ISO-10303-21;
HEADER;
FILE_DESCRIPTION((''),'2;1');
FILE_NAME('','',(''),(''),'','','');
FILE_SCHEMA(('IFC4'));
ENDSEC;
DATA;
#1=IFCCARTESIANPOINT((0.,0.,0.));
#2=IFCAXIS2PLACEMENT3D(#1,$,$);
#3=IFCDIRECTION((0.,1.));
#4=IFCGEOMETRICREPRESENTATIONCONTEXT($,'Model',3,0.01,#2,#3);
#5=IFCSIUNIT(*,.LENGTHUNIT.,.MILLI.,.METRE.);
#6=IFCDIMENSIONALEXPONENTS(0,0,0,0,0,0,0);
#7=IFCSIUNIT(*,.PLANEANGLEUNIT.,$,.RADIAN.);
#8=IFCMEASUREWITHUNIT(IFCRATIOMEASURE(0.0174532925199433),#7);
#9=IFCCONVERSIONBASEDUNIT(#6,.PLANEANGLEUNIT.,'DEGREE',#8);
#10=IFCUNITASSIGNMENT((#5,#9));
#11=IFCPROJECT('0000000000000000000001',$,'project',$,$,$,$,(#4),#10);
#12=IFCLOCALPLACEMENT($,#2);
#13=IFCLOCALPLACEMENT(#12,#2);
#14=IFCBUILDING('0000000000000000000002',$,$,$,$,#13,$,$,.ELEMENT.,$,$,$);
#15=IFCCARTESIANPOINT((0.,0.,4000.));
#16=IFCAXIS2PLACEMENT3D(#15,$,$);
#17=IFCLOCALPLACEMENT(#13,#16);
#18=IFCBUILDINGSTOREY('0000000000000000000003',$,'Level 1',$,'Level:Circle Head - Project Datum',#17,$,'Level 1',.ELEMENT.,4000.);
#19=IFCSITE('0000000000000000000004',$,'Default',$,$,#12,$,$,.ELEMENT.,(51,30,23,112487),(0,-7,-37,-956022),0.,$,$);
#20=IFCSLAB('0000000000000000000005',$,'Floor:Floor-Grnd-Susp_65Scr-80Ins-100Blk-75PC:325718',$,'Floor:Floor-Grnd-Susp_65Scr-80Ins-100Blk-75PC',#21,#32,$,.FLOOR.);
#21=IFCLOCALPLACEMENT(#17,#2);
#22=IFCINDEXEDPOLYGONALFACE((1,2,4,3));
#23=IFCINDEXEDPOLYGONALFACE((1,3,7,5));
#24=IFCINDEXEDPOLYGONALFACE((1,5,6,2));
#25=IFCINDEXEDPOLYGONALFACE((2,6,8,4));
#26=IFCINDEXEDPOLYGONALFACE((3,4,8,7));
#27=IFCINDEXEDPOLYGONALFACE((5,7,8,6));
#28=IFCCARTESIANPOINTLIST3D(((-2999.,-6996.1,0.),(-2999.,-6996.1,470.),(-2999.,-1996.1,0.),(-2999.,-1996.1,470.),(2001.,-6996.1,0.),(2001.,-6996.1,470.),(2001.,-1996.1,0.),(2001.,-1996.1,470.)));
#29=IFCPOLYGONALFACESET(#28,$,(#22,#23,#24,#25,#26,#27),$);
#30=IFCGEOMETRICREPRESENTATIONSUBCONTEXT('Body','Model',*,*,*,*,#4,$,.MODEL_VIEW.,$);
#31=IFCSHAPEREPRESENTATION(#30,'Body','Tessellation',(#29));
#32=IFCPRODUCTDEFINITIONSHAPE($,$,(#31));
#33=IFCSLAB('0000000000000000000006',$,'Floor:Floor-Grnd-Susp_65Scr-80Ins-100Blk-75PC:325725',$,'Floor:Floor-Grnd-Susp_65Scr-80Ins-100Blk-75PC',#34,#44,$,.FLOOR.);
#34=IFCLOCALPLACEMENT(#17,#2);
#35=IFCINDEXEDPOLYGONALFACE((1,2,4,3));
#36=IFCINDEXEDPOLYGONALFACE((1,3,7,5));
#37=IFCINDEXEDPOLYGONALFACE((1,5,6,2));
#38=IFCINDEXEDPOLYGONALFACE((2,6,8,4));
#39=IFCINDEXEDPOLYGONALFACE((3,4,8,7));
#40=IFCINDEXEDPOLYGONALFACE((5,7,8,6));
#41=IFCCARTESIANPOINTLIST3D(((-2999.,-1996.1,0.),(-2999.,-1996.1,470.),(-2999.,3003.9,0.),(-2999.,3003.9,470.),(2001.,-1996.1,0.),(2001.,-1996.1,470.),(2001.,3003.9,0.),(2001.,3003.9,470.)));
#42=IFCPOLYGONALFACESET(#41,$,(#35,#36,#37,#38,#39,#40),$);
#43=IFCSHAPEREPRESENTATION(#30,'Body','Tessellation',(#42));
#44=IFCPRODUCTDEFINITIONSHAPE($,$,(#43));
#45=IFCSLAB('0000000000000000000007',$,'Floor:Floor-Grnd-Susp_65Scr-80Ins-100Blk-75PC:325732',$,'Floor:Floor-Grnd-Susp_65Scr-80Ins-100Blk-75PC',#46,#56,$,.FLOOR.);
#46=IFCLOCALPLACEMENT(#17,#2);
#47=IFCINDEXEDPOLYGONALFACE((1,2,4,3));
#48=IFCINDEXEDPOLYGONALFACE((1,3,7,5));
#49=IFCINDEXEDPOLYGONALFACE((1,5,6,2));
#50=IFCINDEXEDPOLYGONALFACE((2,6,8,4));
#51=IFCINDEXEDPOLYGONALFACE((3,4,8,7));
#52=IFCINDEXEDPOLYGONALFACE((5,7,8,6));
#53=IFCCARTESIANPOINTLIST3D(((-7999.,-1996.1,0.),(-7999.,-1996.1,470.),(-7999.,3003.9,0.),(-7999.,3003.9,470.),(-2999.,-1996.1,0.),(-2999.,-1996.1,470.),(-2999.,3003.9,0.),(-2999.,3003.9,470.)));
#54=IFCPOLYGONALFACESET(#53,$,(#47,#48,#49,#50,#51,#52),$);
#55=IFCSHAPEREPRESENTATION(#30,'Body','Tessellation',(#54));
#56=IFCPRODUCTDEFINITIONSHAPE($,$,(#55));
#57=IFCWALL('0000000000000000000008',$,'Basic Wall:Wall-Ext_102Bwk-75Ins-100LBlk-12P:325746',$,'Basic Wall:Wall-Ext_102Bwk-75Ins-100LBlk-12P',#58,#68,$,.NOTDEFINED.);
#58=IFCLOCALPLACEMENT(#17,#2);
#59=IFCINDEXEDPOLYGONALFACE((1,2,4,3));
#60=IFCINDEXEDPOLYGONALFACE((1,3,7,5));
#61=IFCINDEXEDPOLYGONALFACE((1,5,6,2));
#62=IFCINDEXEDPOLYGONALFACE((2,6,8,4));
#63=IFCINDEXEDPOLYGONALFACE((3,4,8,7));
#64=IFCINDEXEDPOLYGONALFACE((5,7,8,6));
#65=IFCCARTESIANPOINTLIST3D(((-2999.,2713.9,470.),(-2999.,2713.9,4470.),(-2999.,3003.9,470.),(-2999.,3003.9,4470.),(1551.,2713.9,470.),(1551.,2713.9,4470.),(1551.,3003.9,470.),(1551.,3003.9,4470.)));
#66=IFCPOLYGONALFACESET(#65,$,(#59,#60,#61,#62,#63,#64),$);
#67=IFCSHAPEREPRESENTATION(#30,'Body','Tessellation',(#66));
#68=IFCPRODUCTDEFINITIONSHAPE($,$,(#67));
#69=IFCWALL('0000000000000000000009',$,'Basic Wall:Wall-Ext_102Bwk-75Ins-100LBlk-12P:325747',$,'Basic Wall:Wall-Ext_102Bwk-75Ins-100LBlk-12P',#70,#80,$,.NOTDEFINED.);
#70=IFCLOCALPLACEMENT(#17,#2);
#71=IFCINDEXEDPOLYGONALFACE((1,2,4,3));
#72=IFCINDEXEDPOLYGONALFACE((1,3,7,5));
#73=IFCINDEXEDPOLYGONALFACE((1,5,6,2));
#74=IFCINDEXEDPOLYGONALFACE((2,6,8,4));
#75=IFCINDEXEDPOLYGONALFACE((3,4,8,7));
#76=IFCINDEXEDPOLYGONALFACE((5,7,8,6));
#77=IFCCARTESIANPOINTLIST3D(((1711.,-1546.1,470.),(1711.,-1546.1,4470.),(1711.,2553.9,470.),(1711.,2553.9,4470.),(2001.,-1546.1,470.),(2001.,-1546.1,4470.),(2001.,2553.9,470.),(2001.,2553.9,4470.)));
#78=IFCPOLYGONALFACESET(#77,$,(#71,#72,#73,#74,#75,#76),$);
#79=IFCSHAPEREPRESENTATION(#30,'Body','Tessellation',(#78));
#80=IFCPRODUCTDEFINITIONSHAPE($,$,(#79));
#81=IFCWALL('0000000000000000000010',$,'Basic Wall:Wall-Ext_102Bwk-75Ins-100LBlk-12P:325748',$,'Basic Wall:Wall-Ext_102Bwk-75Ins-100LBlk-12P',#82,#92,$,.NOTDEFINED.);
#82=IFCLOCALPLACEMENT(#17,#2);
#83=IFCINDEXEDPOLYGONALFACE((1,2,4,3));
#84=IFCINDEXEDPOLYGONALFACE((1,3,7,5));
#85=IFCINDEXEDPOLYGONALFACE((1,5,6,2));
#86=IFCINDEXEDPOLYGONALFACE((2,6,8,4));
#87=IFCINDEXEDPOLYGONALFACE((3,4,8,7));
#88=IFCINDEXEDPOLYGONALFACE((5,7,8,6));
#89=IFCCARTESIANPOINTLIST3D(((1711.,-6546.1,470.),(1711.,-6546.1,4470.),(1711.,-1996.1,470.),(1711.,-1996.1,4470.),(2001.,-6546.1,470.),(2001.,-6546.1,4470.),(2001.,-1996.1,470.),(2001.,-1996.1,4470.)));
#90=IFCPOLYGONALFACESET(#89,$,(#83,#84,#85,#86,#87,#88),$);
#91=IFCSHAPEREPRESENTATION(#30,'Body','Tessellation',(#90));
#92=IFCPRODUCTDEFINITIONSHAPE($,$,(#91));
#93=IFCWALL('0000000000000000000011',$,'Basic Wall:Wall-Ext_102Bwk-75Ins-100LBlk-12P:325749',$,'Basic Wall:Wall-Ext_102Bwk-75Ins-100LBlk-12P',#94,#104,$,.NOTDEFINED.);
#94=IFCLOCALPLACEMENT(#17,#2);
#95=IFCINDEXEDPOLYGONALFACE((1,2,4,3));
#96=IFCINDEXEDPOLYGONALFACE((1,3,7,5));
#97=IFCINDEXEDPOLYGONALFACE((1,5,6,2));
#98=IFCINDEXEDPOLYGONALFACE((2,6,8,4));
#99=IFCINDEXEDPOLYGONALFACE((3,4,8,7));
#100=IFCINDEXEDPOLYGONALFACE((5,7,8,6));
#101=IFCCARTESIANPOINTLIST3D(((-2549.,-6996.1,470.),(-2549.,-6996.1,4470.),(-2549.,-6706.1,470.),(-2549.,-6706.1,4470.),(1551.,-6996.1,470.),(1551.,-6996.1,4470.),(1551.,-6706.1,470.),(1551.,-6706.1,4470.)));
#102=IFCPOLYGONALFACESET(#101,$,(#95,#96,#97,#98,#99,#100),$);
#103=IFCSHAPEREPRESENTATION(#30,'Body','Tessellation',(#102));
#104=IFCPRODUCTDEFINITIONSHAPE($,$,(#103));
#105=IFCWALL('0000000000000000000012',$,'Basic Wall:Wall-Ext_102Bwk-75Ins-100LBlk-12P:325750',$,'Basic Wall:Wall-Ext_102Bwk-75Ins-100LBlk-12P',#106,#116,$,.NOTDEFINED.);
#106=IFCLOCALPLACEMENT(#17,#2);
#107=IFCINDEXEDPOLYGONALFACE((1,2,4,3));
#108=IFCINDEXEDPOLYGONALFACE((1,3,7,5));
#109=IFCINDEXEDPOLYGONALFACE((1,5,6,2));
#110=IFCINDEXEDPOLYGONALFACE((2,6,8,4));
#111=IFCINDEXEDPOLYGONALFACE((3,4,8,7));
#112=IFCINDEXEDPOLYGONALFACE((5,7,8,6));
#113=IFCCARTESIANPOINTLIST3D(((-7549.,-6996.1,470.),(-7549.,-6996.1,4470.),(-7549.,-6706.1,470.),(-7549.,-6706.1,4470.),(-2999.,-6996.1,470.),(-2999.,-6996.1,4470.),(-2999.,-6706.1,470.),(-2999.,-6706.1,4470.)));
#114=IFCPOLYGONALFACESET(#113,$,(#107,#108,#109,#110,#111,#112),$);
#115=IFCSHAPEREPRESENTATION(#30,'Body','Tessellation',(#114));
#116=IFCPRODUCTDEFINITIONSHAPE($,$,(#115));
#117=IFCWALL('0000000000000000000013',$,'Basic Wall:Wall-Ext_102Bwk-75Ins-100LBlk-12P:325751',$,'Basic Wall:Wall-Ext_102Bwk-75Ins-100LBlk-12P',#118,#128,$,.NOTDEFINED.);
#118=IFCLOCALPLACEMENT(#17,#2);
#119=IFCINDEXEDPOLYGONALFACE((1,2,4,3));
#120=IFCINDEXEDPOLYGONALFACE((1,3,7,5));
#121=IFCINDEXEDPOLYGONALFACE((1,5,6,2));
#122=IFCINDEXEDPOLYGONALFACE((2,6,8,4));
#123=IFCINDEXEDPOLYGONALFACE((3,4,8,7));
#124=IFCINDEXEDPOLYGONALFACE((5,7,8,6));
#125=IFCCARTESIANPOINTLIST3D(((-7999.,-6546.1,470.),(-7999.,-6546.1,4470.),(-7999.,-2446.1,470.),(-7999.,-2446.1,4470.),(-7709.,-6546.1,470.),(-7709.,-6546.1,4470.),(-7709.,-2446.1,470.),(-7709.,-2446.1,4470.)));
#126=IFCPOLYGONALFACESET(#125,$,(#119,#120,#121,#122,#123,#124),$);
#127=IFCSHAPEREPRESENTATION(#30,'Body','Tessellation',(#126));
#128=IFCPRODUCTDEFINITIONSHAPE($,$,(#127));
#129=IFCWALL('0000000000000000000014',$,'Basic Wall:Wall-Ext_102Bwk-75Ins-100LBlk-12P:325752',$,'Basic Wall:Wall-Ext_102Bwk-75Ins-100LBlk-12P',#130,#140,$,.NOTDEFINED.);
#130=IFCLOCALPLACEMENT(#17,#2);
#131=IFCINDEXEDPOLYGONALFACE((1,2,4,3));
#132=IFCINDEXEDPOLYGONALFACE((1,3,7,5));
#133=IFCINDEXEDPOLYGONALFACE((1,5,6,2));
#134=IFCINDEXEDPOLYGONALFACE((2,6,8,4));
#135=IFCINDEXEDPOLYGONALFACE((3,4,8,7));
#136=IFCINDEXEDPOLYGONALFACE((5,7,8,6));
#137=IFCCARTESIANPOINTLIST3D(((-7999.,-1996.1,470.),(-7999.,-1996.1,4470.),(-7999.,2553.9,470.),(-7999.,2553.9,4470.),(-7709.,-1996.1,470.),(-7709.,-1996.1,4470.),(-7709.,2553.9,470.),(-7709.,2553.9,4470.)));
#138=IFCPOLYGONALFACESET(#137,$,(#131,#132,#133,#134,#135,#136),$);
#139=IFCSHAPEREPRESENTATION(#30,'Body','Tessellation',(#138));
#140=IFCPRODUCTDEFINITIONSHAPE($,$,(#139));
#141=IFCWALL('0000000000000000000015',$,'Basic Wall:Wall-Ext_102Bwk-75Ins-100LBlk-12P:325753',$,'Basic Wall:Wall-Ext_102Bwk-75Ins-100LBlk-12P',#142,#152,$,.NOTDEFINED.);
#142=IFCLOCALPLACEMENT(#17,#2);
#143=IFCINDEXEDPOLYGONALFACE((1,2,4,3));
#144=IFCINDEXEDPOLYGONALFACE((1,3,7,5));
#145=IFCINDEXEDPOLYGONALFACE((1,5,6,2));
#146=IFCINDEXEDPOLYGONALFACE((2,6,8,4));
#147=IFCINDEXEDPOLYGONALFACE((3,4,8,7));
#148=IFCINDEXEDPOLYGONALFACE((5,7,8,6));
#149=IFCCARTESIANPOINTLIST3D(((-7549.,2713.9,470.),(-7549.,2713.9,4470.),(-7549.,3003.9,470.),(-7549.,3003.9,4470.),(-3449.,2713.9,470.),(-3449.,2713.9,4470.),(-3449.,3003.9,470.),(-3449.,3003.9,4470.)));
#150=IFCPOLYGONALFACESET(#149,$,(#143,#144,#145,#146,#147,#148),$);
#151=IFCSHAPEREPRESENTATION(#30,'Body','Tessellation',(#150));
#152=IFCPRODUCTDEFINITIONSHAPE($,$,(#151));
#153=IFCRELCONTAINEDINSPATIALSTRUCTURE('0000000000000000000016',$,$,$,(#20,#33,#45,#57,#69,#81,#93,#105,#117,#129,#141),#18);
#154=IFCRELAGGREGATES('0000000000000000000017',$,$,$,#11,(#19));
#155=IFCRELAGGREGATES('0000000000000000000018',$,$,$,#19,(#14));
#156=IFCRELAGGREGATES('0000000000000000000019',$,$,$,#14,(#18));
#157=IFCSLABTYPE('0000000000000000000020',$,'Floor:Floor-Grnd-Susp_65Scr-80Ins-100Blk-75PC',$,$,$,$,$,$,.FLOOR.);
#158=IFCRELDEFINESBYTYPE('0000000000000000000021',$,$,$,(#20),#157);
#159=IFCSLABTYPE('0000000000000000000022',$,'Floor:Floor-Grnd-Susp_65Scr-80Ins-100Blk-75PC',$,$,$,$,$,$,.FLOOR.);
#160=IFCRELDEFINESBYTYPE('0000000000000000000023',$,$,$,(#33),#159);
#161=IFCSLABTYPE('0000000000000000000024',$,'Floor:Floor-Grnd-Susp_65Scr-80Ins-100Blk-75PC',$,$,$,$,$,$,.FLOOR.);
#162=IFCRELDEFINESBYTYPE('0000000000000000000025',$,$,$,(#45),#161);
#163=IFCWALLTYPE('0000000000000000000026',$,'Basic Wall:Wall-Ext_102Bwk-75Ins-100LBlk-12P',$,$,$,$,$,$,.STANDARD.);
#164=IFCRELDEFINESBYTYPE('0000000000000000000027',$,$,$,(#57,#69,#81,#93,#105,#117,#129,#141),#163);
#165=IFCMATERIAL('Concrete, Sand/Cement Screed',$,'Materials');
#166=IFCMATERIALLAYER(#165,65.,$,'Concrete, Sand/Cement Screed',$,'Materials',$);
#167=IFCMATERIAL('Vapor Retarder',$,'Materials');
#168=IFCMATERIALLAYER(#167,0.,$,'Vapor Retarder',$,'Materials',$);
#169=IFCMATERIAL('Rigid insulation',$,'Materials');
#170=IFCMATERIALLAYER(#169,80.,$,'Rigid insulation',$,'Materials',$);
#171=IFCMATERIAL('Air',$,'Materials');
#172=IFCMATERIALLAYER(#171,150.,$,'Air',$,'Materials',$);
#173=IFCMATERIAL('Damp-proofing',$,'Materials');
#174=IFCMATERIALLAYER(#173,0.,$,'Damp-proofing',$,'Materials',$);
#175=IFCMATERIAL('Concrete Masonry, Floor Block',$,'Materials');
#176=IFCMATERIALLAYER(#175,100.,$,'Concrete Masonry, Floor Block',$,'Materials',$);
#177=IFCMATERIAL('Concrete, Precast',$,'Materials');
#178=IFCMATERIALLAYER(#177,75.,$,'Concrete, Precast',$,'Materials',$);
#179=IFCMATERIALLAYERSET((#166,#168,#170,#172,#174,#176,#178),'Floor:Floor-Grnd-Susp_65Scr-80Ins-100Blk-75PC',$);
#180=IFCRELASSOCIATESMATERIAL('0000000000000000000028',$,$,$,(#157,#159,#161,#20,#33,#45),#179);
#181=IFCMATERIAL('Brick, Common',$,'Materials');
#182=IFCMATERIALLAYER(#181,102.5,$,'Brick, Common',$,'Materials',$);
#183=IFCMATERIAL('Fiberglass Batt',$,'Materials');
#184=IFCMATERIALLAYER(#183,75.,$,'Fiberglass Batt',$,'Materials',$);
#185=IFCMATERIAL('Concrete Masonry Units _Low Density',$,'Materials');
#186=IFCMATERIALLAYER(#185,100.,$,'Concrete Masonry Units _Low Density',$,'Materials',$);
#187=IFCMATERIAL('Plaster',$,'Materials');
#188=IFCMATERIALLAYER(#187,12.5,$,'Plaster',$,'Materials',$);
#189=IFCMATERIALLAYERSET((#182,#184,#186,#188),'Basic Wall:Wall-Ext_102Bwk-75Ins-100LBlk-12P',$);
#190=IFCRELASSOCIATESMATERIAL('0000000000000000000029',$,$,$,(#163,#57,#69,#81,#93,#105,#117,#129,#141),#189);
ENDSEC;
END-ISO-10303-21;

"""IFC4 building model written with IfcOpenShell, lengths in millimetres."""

from ifc_helpers import new_model, entity, si_unit, converted_unit, direction, frame, frame_2d, origin, origin_2d_with_axis, place, context, subcontext, project, spatial, rectangle, extrude, material, layer, layer_set, layer_usage, type_object, element, save


model = new_model("IFC4")

# Units and contexts
model_context = context("Model", 3, precision=0.01, world=origin(), true_north=direction((0.0, 1.0)))
body_context = subcontext(model_context, "Body", "Model", "MODEL_VIEW")
ifc_project = project(units=[si_unit("LENGTHUNIT", "METRE", prefix="MILLI"), converted_unit("PLANEANGLEUNIT", "DEGREE", entity("IfcRatioMeasure", 0.0174532925199433), si_unit("PLANEANGLEUNIT", "RADIAN"), dimensions=[0, 0, 0, 0, 0, 0, 0])], contexts=[model_context])

# Site, building, storey
site_placement = place(None, origin())
site = spatial("IfcSite", under=ifc_project, at=site_placement, Name="Default", CompositionType="ELEMENT", RefLatitude=(51, 30, 23, 112487), RefLongitude=(0, -7, -37, -956022), RefElevation=0.0)
building_placement = place(site_placement, origin())
building = spatial("IfcBuilding", under=site, at=building_placement, CompositionType="ELEMENT")
storey_placement = place(building_placement, frame((0.0, 0.0, 4000.0)))
storey = spatial("IfcBuildingStorey", under=building, at=storey_placement, Name="Level 1", ObjectType="Level:Circle Head - Project Datum", LongName="Level 1", CompositionType="ELEMENT", Elevation=4000.0)

# Slabs
ifc_material_1 = material(Name="Concrete, Sand/Cement Screed", Category="Materials")
ifc_layer_1 = layer(ifc_material_1, 65.0, Name="Concrete, Sand/Cement Screed", Category="Materials")
ifc_material_2 = material(Name="Vapor Retarder", Category="Materials")
ifc_layer_2 = layer(ifc_material_2, 0.0, Name="Vapor Retarder", Category="Materials")
ifc_material_3 = material(Name="Rigid insulation", Category="Materials")
ifc_layer_3 = layer(ifc_material_3, 80.0, Name="Rigid insulation", Category="Materials")
ifc_material_4 = material(Name="Air", Category="Materials")
ifc_layer_4 = layer(ifc_material_4, 150.0, Name="Air", Category="Materials")
ifc_material_5 = material(Name="Damp-proofing", Category="Materials")
ifc_layer_5 = layer(ifc_material_5, 0.0, Name="Damp-proofing", Category="Materials")
ifc_material_6 = material(Name="Concrete Masonry, Floor Block", Category="Materials")
ifc_layer_6 = layer(ifc_material_6, 100.0, Name="Concrete Masonry, Floor Block", Category="Materials")
ifc_material_7 = material(Name="Concrete, Precast", Category="Materials")
ifc_layer_7 = layer(ifc_material_7, 75.0, Name="Concrete, Precast", Category="Materials")
ifc_layer_set_1 = layer_set([ifc_layer_1, ifc_layer_2, ifc_layer_3, ifc_layer_4, ifc_layer_5, ifc_layer_6, ifc_layer_7], Name="Floor:Floor-Grnd-Susp_65Scr-80Ins-100Blk-75PC")
ifc_layer_usage_1 = layer_usage(ifc_layer_set_1, "AXIS3", "POSITIVE", 0.0)
slab_type_1 = type_object("IfcSlabType", Name="Floor:Floor-Grnd-Susp_65Scr-80Ins-100Blk-75PC", PredefinedType="FLOOR", material=ifc_layer_set_1)
slab_1_placement = place(storey_placement, origin())
element("IfcSlab", 1, at=slab_1_placement, inside=storey, type_object=slab_type_1, material=ifc_layer_usage_1, Name="Floor:Floor-Grnd-Susp_65Scr-80Ins-100Blk-75PC:325718", ObjectType="Floor:Floor-Grnd-Susp_65Scr-80Ins-100Blk-75PC", PredefinedType="FLOOR", context=body_context, shape_type="SweptSolid", body=[
    extrude(rectangle(XDim=5000.0, YDim=5000.0, at=frame_2d((0.0, 0.0), x_axis=(1.0, 0.0))), frame((-499.0, -4496.1, 470.0), z_axis=(0.0, 0.0, -1.0), x_axis=(0.0, 1.0, 0.0)), (0.0, 0.0, 1.0), 470.0),
])
ifc_layer_usage_2 = layer_usage(ifc_layer_set_1, "AXIS3", "POSITIVE", 0.0)
slab_type_2 = type_object("IfcSlabType", Name="Floor:Floor-Grnd-Susp_65Scr-80Ins-100Blk-75PC", PredefinedType="FLOOR", material=ifc_layer_set_1)
slab_2_placement = place(storey_placement, origin())
element("IfcSlab", 2, at=slab_2_placement, inside=storey, type_object=slab_type_2, material=ifc_layer_usage_2, Name="Floor:Floor-Grnd-Susp_65Scr-80Ins-100Blk-75PC:325725", ObjectType="Floor:Floor-Grnd-Susp_65Scr-80Ins-100Blk-75PC", PredefinedType="FLOOR", context=body_context, shape_type="SweptSolid", body=[
    extrude(rectangle(XDim=5000.0, YDim=5000.0, at=origin_2d_with_axis()), frame((-499.0, 503.9, 470.0), z_axis=(0.0, 0.0, -1.0), x_axis=(0.0, 1.0, 0.0)), (0.0, 0.0, 1.0), 470.0),
])
ifc_layer_usage_3 = layer_usage(ifc_layer_set_1, "AXIS3", "POSITIVE", 0.0)
slab_type_3 = type_object("IfcSlabType", Name="Floor:Floor-Grnd-Susp_65Scr-80Ins-100Blk-75PC", PredefinedType="FLOOR", material=ifc_layer_set_1)
slab_3_placement = place(storey_placement, origin())
element("IfcSlab", 3, at=slab_3_placement, inside=storey, type_object=slab_type_3, material=ifc_layer_usage_3, Name="Floor:Floor-Grnd-Susp_65Scr-80Ins-100Blk-75PC:325732", ObjectType="Floor:Floor-Grnd-Susp_65Scr-80Ins-100Blk-75PC", PredefinedType="FLOOR", context=body_context, shape_type="SweptSolid", body=[
    extrude(rectangle(XDim=5000.0, YDim=5000.0, at=origin_2d_with_axis()), frame((-5499.0, 503.9, 470.0), z_axis=(0.0, 0.0, -1.0), x_axis=(0.0, 1.0, 0.0)), (0.0, 0.0, 1.0), 470.0),
])

# Walls
ifc_material_8 = material(Name="Brick, Common", Category="Materials")
ifc_layer_8 = layer(ifc_material_8, 102.5, Name="Brick, Common", Category="Materials")
ifc_material_9 = material(Name="Fiberglass Batt", Category="Materials")
ifc_layer_9 = layer(ifc_material_9, 75.0, Name="Fiberglass Batt", Category="Materials")
ifc_material_10 = material(Name="Concrete Masonry Units _Low Density", Category="Materials")
ifc_layer_10 = layer(ifc_material_10, 100.0, Name="Concrete Masonry Units _Low Density", Category="Materials")
ifc_material_11 = material(Name="Plaster", Category="Materials")
ifc_layer_11 = layer(ifc_material_11, 12.5, Name="Plaster", Category="Materials")
ifc_layer_set_2 = layer_set([ifc_layer_8, ifc_layer_9, ifc_layer_10, ifc_layer_11], Name="Basic Wall:Wall-Ext_102Bwk-75Ins-100LBlk-12P")
ifc_layer_usage_4 = layer_usage(ifc_layer_set_2, "AXIS2", "NEGATIVE", 145.0)
wall_type = type_object("IfcWallType", Name="Basic Wall:Wall-Ext_102Bwk-75Ins-100LBlk-12P", PredefinedType="STANDARD", material=ifc_layer_set_2)
wall_1_placement = place(storey_placement, frame((-2999.0, 2858.9, 470.0)))
element("IfcWall", 4, at=wall_1_placement, inside=storey, type_object=wall_type, material=ifc_layer_usage_4, Name="Basic Wall:Wall-Ext_102Bwk-75Ins-100LBlk-12P:325746", ObjectType="Basic Wall:Wall-Ext_102Bwk-75Ins-100LBlk-12P", PredefinedType="NOTDEFINED", context=body_context, shape_type="SweptSolid", body=[
    extrude(rectangle(XDim=4550.0, YDim=290.0, at=frame_2d((2275.0, 0.0), x_axis=(-1.0, 0.0))), origin(), (0.0, 0.0, 1.0), 4000.0),
])
ifc_layer_usage_5 = layer_usage(ifc_layer_set_2, "AXIS2", "NEGATIVE", 145.0)
wall_2_placement = place(storey_placement, frame((1856.0, 2553.9, 470.0), z_axis=(0.0, 0.0, 1.0), x_axis=(0.0, -1.0, 0.0)))
element("IfcWall", 5, at=wall_2_placement, inside=storey, type_object=wall_type, material=ifc_layer_usage_5, Name="Basic Wall:Wall-Ext_102Bwk-75Ins-100LBlk-12P:325747", ObjectType="Basic Wall:Wall-Ext_102Bwk-75Ins-100LBlk-12P", PredefinedType="NOTDEFINED", context=body_context, shape_type="SweptSolid", body=[
    extrude(rectangle(XDim=4100.0, YDim=290.0, at=frame_2d((2050.0, 0.0), x_axis=(-1.0, 0.0))), origin(), (0.0, 0.0, 1.0), 4000.0),
])
ifc_layer_usage_6 = layer_usage(ifc_layer_set_2, "AXIS2", "NEGATIVE", 145.0)
wall_3_placement = place(storey_placement, frame((1856.0, -1996.1, 470.0), z_axis=(0.0, 0.0, 1.0), x_axis=(0.0, -1.0, 0.0)))
element("IfcWall", 6, at=wall_3_placement, inside=storey, type_object=wall_type, material=ifc_layer_usage_6, Name="Basic Wall:Wall-Ext_102Bwk-75Ins-100LBlk-12P:325748", ObjectType="Basic Wall:Wall-Ext_102Bwk-75Ins-100LBlk-12P", PredefinedType="NOTDEFINED", context=body_context, shape_type="SweptSolid", body=[
    extrude(rectangle(XDim=4550.0, YDim=290.0, at=frame_2d((2275.0, 0.0), x_axis=(-1.0, 0.0))), origin(), (0.0, 0.0, 1.0), 4000.0),
])
ifc_layer_usage_7 = layer_usage(ifc_layer_set_2, "AXIS2", "NEGATIVE", 145.0)
wall_4_placement = place(storey_placement, frame((1551.0, -6851.1, 470.0), z_axis=(0.0, 0.0, 1.0), x_axis=(-1.0, 0.0, 0.0)))
element("IfcWall", 7, at=wall_4_placement, inside=storey, type_object=wall_type, material=ifc_layer_usage_7, Name="Basic Wall:Wall-Ext_102Bwk-75Ins-100LBlk-12P:325749", ObjectType="Basic Wall:Wall-Ext_102Bwk-75Ins-100LBlk-12P", PredefinedType="NOTDEFINED", context=body_context, shape_type="SweptSolid", body=[
    extrude(rectangle(XDim=4100.0, YDim=290.0, at=frame_2d((2050.0, 0.0), x_axis=(-1.0, 0.0))), origin(), (0.0, 0.0, 1.0), 4000.0),
])
ifc_layer_usage_8 = layer_usage(ifc_layer_set_2, "AXIS2", "NEGATIVE", 145.0)
wall_5_placement = place(storey_placement, frame((-2999.0, -6851.1, 470.0), z_axis=(0.0, 0.0, 1.0), x_axis=(-1.0, 0.0, 0.0)))
element("IfcWall", 8, at=wall_5_placement, inside=storey, type_object=wall_type, material=ifc_layer_usage_8, Name="Basic Wall:Wall-Ext_102Bwk-75Ins-100LBlk-12P:325750", ObjectType="Basic Wall:Wall-Ext_102Bwk-75Ins-100LBlk-12P", PredefinedType="NOTDEFINED", context=body_context, shape_type="SweptSolid", body=[
    extrude(rectangle(XDim=4550.0, YDim=290.0, at=frame_2d((2275.0, 0.0), x_axis=(-1.0, 0.0))), origin(), (0.0, 0.0, 1.0), 4000.0),
])
ifc_layer_usage_9 = layer_usage(ifc_layer_set_2, "AXIS2", "NEGATIVE", 145.0)
wall_6_placement = place(storey_placement, frame((-7854.0, -6546.1, 470.0), z_axis=(0.0, 0.0, 1.0), x_axis=(0.0, 1.0, 0.0)))
element("IfcWall", 9, at=wall_6_placement, inside=storey, type_object=wall_type, material=ifc_layer_usage_9, Name="Basic Wall:Wall-Ext_102Bwk-75Ins-100LBlk-12P:325751", ObjectType="Basic Wall:Wall-Ext_102Bwk-75Ins-100LBlk-12P", PredefinedType="NOTDEFINED", context=body_context, shape_type="SweptSolid", body=[
    extrude(rectangle(XDim=4100.0, YDim=290.0, at=frame_2d((2050.0, 0.0), x_axis=(-1.0, 0.0))), origin(), (0.0, 0.0, 1.0), 4000.0),
])
ifc_layer_usage_10 = layer_usage(ifc_layer_set_2, "AXIS2", "NEGATIVE", 145.0)
wall_7_placement = place(storey_placement, frame((-7854.0, -1996.1, 470.0), z_axis=(0.0, 0.0, 1.0), x_axis=(0.0, 1.0, 0.0)))
element("IfcWall", 10, at=wall_7_placement, inside=storey, type_object=wall_type, material=ifc_layer_usage_10, Name="Basic Wall:Wall-Ext_102Bwk-75Ins-100LBlk-12P:325752", ObjectType="Basic Wall:Wall-Ext_102Bwk-75Ins-100LBlk-12P", PredefinedType="NOTDEFINED", context=body_context, shape_type="SweptSolid", body=[
    extrude(rectangle(XDim=4550.0, YDim=290.0, at=frame_2d((2275.0, 0.0), x_axis=(-1.0, 0.0))), origin(), (0.0, 0.0, 1.0), 4000.0),
])
ifc_layer_usage_11 = layer_usage(ifc_layer_set_2, "AXIS2", "NEGATIVE", 145.0)
wall_8_placement = place(storey_placement, frame((-7549.0, 2858.9, 470.0)))
element("IfcWall", 11, at=wall_8_placement, inside=storey, type_object=wall_type, material=ifc_layer_usage_11, Name="Basic Wall:Wall-Ext_102Bwk-75Ins-100LBlk-12P:325753", ObjectType="Basic Wall:Wall-Ext_102Bwk-75Ins-100LBlk-12P", PredefinedType="NOTDEFINED", context=body_context, shape_type="SweptSolid", body=[
    extrude(rectangle(XDim=4100.0, YDim=290.0, at=frame_2d((2050.0, 0.0), x_axis=(-1.0, 0.0))), origin(), (0.0, 0.0, 1.0), 4000.0),
])

save(model, "model.ifc")
